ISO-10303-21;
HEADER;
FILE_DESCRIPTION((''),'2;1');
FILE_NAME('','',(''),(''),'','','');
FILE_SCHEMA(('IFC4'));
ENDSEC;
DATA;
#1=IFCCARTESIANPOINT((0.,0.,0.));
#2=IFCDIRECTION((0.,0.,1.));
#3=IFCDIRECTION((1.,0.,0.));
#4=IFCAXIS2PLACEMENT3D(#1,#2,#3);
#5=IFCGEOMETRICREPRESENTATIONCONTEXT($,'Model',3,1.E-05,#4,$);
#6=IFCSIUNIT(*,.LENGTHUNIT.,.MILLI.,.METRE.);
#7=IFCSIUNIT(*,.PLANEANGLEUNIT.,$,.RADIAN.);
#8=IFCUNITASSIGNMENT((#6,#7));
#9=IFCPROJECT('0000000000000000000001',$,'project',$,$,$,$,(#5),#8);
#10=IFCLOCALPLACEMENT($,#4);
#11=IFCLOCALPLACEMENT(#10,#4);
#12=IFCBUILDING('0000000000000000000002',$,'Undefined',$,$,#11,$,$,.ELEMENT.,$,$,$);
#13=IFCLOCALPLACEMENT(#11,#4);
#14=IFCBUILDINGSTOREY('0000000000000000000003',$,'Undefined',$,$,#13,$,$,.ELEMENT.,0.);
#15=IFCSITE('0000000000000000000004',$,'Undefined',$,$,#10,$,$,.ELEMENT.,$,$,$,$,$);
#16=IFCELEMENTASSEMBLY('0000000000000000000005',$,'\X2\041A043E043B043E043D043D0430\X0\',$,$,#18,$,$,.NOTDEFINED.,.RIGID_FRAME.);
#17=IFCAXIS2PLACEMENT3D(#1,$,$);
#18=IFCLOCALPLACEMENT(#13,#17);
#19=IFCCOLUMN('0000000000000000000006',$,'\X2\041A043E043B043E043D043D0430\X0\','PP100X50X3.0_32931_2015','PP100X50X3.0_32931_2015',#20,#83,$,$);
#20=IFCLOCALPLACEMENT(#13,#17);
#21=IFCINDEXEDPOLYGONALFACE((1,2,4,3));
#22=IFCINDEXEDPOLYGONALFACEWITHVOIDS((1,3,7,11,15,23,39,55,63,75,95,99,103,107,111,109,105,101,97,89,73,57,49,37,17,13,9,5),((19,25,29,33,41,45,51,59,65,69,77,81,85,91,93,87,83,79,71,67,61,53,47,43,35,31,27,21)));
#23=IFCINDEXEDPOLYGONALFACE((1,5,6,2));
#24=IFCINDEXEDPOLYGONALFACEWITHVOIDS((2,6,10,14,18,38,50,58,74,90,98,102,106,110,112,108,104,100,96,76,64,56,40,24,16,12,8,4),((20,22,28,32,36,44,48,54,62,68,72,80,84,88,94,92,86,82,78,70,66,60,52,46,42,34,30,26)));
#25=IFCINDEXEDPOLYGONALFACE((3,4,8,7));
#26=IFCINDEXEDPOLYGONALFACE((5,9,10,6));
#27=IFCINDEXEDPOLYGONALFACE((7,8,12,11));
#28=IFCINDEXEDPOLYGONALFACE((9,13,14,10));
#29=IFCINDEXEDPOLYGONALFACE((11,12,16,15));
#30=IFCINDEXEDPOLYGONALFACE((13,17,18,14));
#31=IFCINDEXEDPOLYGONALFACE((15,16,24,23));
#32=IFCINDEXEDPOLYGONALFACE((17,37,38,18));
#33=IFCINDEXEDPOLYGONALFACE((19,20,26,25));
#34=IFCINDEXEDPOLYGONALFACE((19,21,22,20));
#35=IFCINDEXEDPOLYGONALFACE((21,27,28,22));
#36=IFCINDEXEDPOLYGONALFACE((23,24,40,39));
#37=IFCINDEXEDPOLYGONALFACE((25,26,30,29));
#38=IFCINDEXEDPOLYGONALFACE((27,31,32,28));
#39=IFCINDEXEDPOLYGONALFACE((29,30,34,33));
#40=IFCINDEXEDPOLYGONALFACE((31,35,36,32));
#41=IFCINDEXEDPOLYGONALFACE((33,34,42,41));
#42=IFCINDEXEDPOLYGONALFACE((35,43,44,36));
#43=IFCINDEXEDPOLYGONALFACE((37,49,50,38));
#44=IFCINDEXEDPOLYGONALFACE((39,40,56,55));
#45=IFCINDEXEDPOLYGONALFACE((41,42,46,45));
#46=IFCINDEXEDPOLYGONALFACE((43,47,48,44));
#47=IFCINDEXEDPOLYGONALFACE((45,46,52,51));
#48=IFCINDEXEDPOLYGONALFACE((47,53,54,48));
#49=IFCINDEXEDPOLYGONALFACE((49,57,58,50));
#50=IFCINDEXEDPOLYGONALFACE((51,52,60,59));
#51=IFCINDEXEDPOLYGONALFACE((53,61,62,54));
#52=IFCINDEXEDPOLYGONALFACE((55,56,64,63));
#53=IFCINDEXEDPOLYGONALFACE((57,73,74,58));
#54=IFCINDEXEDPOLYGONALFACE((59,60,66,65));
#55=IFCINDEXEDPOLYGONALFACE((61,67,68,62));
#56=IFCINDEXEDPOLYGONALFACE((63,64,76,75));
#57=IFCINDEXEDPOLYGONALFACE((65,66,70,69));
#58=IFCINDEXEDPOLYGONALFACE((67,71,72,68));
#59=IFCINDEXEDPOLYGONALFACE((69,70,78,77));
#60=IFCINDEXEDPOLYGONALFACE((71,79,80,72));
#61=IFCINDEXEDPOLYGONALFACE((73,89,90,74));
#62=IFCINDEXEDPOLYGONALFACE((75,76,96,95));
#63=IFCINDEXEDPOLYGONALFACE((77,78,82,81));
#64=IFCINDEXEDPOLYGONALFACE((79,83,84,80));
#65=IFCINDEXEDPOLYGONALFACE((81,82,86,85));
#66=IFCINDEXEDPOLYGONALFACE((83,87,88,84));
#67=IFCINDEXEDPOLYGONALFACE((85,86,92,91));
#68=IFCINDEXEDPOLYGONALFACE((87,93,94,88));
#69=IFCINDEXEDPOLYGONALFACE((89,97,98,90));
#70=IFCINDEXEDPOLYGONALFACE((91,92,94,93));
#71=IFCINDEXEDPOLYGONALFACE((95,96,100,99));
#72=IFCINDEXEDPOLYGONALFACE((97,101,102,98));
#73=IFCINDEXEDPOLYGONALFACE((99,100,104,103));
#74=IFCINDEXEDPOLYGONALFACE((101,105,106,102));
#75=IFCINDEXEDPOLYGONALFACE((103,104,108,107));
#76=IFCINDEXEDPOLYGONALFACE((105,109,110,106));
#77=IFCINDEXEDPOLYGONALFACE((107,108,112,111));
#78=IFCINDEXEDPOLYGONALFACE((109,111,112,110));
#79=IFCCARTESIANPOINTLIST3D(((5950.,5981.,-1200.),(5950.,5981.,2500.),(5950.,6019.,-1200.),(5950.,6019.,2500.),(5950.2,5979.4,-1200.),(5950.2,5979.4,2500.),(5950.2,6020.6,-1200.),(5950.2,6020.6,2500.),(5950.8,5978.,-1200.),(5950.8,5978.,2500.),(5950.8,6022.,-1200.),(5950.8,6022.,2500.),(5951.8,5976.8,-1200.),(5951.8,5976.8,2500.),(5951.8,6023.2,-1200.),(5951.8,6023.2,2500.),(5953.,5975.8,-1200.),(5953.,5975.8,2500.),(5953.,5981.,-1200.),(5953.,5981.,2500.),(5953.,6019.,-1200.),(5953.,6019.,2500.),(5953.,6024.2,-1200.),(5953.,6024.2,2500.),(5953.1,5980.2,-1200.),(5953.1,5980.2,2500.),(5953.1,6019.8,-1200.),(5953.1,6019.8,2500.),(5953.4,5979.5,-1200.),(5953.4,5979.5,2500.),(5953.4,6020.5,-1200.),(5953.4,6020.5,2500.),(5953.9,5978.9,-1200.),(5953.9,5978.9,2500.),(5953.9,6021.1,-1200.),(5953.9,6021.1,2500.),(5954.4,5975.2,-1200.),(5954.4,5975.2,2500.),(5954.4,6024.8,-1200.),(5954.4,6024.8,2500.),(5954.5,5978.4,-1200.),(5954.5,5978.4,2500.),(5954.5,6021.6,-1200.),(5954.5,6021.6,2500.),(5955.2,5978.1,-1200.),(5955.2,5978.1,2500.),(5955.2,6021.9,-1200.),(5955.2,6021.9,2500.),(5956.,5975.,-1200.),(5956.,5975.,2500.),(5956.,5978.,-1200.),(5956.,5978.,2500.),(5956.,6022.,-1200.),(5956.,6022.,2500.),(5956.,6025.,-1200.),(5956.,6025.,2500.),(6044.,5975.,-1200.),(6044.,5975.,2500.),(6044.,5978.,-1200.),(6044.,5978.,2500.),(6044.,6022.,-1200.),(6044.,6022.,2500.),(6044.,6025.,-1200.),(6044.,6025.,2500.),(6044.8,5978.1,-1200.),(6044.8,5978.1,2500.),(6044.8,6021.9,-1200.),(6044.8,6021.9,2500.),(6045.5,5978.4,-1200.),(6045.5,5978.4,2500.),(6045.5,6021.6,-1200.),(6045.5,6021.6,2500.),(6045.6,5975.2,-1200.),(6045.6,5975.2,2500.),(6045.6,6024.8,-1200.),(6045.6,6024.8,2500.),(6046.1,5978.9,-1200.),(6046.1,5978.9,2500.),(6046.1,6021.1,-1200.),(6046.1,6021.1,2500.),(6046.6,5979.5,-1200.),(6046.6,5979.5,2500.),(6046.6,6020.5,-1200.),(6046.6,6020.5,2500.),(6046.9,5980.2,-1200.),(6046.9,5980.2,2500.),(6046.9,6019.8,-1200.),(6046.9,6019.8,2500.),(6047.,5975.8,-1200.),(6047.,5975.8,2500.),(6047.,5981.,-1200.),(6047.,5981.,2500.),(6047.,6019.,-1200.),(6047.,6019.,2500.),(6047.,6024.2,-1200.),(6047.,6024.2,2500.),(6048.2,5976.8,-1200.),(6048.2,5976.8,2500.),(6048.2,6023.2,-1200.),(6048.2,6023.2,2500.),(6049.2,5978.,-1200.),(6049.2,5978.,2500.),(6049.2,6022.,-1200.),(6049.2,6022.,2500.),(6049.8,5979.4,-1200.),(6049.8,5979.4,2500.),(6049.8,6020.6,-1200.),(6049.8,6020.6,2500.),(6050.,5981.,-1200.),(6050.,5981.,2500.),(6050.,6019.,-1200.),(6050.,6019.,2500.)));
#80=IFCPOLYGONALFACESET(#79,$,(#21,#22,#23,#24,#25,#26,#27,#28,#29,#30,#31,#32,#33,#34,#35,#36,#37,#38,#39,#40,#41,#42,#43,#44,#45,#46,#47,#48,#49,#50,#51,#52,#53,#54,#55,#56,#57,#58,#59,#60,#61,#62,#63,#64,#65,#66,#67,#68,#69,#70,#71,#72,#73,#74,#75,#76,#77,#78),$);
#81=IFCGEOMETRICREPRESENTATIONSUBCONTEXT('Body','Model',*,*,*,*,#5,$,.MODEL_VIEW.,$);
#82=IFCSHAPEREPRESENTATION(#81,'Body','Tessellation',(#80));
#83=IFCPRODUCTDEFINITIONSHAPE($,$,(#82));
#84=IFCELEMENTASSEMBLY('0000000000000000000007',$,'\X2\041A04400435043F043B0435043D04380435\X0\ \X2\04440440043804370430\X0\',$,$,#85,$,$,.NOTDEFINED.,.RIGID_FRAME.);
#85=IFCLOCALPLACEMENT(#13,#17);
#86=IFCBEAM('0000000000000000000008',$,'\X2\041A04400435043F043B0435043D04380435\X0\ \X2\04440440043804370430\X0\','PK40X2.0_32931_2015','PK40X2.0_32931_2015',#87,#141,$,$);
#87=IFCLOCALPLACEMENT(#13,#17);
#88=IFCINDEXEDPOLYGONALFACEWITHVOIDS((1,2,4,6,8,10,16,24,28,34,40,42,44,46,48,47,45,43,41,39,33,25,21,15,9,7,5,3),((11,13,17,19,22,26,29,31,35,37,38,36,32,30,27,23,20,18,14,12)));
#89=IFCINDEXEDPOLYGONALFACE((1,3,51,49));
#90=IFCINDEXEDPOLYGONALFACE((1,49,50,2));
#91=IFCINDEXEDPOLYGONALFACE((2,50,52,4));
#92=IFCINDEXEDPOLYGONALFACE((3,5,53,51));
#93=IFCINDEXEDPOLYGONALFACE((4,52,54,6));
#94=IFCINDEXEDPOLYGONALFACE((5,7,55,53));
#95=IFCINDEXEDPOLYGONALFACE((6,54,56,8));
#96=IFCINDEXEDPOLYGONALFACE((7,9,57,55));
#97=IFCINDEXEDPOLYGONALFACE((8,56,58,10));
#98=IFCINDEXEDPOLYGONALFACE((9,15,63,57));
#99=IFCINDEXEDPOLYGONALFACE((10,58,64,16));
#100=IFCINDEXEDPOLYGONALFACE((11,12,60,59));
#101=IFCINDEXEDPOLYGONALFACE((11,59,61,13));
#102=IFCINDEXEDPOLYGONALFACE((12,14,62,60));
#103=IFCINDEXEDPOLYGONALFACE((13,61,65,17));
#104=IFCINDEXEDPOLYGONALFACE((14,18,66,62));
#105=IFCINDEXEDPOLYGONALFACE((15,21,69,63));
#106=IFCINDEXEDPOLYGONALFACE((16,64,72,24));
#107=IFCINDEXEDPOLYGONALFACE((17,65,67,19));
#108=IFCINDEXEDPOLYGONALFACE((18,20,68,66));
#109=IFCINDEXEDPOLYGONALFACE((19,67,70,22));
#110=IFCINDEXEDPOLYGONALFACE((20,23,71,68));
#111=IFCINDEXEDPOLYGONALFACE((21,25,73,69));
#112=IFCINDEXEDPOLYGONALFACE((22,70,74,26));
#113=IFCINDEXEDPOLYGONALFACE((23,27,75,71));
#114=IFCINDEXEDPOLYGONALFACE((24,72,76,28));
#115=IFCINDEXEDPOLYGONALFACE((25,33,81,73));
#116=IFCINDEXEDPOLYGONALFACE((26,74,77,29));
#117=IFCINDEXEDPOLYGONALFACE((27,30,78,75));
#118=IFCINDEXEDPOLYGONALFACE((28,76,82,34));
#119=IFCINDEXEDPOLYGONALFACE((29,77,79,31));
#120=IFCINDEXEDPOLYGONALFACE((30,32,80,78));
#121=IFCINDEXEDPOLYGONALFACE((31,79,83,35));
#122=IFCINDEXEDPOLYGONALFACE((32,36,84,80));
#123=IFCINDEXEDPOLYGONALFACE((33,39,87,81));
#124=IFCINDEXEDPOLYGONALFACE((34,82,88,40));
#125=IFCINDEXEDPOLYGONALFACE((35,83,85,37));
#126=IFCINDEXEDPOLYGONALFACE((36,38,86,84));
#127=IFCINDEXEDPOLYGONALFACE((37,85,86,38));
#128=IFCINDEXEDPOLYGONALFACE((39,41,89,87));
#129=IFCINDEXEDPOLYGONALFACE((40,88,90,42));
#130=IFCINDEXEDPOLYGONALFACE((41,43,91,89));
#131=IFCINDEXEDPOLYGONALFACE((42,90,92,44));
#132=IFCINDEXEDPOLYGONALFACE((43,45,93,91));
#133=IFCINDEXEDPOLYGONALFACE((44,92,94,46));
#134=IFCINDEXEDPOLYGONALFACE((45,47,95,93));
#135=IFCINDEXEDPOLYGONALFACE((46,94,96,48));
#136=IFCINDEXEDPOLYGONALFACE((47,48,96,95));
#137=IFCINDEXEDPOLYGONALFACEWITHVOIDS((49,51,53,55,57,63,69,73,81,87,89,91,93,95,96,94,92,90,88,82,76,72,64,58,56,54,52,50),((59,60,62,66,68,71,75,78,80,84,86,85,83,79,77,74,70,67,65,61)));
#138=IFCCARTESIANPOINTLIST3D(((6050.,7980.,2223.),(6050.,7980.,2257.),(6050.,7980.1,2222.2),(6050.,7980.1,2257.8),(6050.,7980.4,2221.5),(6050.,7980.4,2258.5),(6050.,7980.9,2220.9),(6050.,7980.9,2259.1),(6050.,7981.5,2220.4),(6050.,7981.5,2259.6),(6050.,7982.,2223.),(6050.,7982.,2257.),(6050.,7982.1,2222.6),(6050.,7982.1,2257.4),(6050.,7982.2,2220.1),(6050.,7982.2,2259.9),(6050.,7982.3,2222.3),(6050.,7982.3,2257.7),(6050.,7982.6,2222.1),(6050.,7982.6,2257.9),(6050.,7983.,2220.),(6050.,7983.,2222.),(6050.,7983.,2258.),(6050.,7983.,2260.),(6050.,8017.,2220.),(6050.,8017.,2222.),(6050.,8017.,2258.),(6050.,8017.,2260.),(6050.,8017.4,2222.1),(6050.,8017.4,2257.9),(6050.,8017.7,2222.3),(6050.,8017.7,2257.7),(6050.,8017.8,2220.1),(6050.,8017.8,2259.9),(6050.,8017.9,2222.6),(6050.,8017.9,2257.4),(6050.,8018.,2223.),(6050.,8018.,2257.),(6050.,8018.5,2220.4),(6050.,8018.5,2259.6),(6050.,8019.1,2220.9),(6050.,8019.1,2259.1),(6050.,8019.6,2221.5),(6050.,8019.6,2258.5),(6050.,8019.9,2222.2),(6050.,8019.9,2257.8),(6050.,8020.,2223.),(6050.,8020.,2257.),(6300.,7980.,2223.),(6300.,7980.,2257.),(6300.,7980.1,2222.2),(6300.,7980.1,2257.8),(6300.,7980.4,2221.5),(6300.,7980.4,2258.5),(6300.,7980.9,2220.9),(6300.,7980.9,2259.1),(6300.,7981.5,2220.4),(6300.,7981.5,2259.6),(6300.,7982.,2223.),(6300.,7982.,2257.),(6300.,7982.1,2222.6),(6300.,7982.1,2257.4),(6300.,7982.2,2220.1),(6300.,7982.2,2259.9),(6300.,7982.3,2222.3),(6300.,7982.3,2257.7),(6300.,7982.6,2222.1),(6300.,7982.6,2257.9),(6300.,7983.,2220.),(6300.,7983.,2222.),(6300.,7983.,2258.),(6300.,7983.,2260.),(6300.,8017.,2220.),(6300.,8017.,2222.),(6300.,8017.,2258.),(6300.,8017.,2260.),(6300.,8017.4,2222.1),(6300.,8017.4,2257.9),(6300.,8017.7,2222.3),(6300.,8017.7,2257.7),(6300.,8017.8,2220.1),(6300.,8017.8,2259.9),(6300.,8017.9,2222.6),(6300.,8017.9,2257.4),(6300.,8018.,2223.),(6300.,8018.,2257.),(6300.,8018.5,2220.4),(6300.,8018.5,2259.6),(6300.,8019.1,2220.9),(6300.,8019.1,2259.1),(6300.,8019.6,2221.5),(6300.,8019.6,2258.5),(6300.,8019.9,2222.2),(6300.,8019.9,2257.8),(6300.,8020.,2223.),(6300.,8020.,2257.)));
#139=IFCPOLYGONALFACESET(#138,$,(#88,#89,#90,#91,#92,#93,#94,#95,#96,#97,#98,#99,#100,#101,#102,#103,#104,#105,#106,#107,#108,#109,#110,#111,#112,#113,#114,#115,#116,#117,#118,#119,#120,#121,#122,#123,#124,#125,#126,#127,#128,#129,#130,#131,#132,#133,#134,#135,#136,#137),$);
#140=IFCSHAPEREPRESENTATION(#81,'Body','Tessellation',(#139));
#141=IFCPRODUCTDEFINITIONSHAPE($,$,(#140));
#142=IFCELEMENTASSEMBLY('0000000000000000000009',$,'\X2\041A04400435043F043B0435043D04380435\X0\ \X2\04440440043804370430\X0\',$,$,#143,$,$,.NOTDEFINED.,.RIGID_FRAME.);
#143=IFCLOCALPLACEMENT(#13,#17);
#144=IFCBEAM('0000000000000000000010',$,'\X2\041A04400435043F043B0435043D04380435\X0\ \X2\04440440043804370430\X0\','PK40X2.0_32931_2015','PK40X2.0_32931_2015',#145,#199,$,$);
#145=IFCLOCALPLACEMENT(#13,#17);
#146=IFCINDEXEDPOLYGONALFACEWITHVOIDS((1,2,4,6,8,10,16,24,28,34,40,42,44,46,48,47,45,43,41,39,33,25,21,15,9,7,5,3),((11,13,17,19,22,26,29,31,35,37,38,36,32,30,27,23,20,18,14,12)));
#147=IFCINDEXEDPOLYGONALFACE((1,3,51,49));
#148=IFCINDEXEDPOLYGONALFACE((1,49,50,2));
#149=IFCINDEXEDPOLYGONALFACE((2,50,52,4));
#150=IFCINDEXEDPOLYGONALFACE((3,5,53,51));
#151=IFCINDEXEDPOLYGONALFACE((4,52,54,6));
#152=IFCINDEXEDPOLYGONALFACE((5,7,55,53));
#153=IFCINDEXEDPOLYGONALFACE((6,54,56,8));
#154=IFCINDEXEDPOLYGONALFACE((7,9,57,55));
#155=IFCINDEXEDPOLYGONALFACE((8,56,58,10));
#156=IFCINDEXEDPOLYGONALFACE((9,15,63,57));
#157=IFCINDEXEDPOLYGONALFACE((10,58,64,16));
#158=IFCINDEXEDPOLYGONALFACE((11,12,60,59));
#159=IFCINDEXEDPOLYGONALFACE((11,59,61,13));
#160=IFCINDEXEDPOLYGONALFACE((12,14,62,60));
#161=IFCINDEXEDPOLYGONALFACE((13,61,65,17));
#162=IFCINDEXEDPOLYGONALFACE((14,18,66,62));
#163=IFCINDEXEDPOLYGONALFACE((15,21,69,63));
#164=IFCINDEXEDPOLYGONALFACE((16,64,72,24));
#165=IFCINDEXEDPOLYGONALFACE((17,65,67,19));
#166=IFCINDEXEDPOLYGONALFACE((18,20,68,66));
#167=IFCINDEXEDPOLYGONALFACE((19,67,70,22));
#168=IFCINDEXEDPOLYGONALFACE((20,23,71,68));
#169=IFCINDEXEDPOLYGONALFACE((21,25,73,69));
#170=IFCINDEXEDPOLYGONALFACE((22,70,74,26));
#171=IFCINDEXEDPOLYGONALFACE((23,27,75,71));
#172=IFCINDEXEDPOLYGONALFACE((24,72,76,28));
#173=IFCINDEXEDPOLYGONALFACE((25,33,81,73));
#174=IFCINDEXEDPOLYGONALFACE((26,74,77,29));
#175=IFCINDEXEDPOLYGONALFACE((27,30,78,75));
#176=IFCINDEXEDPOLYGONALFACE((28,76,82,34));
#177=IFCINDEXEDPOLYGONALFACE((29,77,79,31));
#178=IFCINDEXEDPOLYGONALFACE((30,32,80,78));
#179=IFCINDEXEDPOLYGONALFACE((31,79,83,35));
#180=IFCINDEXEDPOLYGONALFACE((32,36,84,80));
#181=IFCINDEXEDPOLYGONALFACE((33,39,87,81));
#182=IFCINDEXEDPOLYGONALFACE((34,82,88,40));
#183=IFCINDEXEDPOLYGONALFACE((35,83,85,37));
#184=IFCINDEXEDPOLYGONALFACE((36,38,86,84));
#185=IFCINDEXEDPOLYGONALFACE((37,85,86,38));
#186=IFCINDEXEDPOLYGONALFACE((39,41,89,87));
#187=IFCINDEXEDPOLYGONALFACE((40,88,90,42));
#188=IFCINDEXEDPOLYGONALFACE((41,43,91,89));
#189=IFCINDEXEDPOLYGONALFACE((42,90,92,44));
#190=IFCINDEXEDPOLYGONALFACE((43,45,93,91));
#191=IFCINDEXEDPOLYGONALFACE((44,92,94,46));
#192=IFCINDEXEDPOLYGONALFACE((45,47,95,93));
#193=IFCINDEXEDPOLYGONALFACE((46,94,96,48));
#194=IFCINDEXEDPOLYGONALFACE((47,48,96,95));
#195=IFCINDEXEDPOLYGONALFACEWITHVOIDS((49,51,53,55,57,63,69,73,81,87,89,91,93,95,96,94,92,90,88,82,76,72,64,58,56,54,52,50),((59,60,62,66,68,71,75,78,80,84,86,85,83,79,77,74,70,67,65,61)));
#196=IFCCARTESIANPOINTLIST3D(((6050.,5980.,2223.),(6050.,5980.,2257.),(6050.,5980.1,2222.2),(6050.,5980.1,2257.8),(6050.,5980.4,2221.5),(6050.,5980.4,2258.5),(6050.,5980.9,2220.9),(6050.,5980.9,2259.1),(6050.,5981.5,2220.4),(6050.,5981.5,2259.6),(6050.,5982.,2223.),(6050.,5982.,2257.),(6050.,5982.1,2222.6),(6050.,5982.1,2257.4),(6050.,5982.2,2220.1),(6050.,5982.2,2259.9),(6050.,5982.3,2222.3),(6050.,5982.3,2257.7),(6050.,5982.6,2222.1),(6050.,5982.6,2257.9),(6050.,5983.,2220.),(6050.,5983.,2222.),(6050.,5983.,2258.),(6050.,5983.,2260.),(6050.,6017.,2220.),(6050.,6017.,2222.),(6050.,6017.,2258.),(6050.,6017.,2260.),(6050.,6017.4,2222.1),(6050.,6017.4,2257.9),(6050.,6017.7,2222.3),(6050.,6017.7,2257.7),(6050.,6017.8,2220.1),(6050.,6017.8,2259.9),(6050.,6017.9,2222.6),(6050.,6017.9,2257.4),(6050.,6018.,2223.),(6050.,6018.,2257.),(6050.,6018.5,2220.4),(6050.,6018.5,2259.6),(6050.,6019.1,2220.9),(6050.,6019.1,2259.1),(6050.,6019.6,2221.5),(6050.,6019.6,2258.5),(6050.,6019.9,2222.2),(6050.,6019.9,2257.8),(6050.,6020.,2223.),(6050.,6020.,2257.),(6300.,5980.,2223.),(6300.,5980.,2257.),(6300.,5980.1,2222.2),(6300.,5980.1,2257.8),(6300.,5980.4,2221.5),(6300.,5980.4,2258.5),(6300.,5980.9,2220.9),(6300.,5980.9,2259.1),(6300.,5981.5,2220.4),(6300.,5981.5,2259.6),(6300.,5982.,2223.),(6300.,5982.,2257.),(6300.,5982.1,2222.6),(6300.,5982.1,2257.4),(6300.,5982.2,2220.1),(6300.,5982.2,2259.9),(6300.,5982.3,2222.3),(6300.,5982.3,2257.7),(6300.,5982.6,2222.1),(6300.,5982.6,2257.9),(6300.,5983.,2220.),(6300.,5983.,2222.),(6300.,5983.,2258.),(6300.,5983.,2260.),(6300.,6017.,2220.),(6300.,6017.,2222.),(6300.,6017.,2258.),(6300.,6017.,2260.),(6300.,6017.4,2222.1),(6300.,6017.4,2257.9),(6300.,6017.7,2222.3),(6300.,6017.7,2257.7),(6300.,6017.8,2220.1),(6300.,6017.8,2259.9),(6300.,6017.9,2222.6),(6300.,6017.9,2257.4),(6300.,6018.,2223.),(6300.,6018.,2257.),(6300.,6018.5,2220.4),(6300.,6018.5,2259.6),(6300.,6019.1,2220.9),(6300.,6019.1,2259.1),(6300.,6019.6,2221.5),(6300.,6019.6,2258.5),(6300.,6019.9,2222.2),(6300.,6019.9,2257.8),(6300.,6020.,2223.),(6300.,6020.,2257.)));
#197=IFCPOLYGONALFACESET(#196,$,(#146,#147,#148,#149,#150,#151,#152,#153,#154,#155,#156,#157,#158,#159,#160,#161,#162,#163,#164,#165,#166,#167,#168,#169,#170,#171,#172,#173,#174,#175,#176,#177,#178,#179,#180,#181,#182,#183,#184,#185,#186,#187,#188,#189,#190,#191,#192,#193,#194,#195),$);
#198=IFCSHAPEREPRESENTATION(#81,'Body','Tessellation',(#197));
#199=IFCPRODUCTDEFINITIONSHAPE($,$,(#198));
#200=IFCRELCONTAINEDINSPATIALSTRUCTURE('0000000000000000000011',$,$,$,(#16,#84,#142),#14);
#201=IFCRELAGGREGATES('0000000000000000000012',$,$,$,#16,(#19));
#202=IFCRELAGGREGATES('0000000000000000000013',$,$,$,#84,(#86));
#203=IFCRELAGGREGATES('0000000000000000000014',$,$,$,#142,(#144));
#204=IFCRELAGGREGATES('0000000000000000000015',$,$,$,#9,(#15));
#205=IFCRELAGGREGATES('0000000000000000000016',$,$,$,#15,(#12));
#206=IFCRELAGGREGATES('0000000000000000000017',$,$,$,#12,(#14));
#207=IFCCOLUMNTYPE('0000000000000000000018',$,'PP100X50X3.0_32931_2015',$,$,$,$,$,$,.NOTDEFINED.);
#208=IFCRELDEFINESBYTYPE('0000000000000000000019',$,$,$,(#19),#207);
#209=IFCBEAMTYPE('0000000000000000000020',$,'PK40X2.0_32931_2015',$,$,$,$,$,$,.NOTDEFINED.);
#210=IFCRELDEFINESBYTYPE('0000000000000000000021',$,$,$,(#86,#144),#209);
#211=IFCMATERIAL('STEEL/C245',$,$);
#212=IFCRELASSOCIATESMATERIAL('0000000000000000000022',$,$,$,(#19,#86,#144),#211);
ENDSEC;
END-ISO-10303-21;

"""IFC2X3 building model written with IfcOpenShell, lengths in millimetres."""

from ifc_helpers import new_model, si_unit, frame, origin_with_axes, origin_2d_with_axis, place, context, subcontext, project, spatial, hollow_rectangle, extrude, material, type_object, element, aggregate, save


model = new_model("IFC2X3")

# Units and contexts
model_context = context("Model", 3, precision=1e-05, world=origin_with_axes())
body_context = subcontext(model_context, "Body", "Model", "MODEL_VIEW")
ifc_project = project(units=[si_unit("LENGTHUNIT", "METRE", prefix="MILLI"), si_unit("PLANEANGLEUNIT", "RADIAN")], contexts=[model_context])

# Site, building, storey
site_placement = place(None, origin_with_axes())
site = spatial("IfcSite", under=ifc_project, at=site_placement, Name="Undefined", CompositionType="ELEMENT")
building_placement = place(site_placement, origin_with_axes())
building = spatial("IfcBuilding", under=site, at=building_placement, Name="Undefined", CompositionType="ELEMENT")
storey_placement = place(building_placement, origin_with_axes())
storey = spatial("IfcBuildingStorey", under=building, at=storey_placement, Name="Undefined", CompositionType="ELEMENT", Elevation=0.0)

# Element assembly, column
ifc_material_1 = material(Name="STEEL/C245")
column_type_1 = type_object("IfcColumnType", Name="PP100X50X3.0_32931_2015", PredefinedType="NOTDEFINED")
assembly_1_placement = place(storey_placement, origin_with_axes())
assembly_1 = element("IfcElementAssembly", 1, at=assembly_1_placement, inside=storey, Name="Колонна", AssemblyPlace="NOTDEFINED", PredefinedType="RIGID_FRAME")
column_1_placement = place(assembly_1_placement, frame((6000.0, 6000.0, -1200.0), z_axis=(0.0, 0.0, 1.0), x_axis=(-1.0, 0.0, 0.0)))
column_1 = element("IfcColumn", 2, at=column_1_placement, type_object=column_type_1, material=ifc_material_1, Name="Колонна", Description="PP100X50X3.0_32931_2015", ObjectType="PP100X50X3.0_32931_2015", context=body_context, shape_type="SweptSolid", body=[
    extrude(hollow_rectangle(XDim=50.0, YDim=100.0, WallThickness=3.0, InnerFilletRadius=3.0, OuterFilletRadius=6.0, at=origin_2d_with_axis()), frame((0.0, 0.0, 3700.0), z_axis=(0.0, 0.0, -1.0), x_axis=(0.0, 1.0, 0.0)), (0.0, 0.0, 1.0), 3700.0),
])
aggregate(assembly_1, [column_1])

# Element assemblies, beams
assembly_2_placement = place(storey_placement, origin_with_axes())
assembly_2 = element("IfcElementAssembly", 3, at=assembly_2_placement, inside=storey, Name="Крепление фриза", AssemblyPlace="NOTDEFINED", PredefinedType="RIGID_FRAME")
beam_type_1 = type_object("IfcBeamType", Name="PK40X2.0_32931_2015", PredefinedType="NOTDEFINED")
beam_1_placement = place(assembly_2_placement, frame((6300.0, 8000.0, 2240.0), z_axis=(0.0, 0.0, -1.0), x_axis=(-1.0, 0.0, 0.0)))
beam_1 = element("IfcBeam", 4, at=beam_1_placement, type_object=beam_type_1, material=ifc_material_1, Name="Крепление фриза", Description="PK40X2.0_32931_2015", ObjectType="PK40X2.0_32931_2015", context=body_context, shape_type="SweptSolid", body=[
    extrude(hollow_rectangle(XDim=40.0, YDim=40.0, WallThickness=2.0, InnerFilletRadius=1.0, OuterFilletRadius=3.0, at=origin_2d_with_axis()), frame((250.0, 0.0, 0.0), z_axis=(-1.0, 0.0, 0.0), x_axis=(0.0, -1.0, 0.0)), (0.0, 0.0, 1.0), 250.0),
])
aggregate(assembly_2, [beam_1])
assembly_3_placement = place(storey_placement, origin_with_axes())
assembly_3 = element("IfcElementAssembly", 5, at=assembly_3_placement, inside=storey, Name="Крепление фриза", AssemblyPlace="NOTDEFINED", PredefinedType="RIGID_FRAME")
beam_2_placement = place(assembly_3_placement, frame((6300.0, 6000.0, 2240.0), z_axis=(0.0, 0.0, -1.0), x_axis=(-1.0, 0.0, 0.0)))
beam_2 = element("IfcBeam", 6, at=beam_2_placement, type_object=beam_type_1, material=ifc_material_1, Name="Крепление фриза", Description="PK40X2.0_32931_2015", ObjectType="PK40X2.0_32931_2015", context=body_context, shape_type="SweptSolid", body=[
    extrude(hollow_rectangle(XDim=40.0, YDim=40.0, WallThickness=2.0, InnerFilletRadius=1.0, OuterFilletRadius=3.0, at=origin_2d_with_axis()), frame((250.0, 0.0, 0.0), z_axis=(-1.0, 0.0, 0.0), x_axis=(0.0, -1.0, 0.0)), (0.0, 0.0, 1.0), 250.0),
])
aggregate(assembly_3, [beam_2])

save(model, "model.ifc")
